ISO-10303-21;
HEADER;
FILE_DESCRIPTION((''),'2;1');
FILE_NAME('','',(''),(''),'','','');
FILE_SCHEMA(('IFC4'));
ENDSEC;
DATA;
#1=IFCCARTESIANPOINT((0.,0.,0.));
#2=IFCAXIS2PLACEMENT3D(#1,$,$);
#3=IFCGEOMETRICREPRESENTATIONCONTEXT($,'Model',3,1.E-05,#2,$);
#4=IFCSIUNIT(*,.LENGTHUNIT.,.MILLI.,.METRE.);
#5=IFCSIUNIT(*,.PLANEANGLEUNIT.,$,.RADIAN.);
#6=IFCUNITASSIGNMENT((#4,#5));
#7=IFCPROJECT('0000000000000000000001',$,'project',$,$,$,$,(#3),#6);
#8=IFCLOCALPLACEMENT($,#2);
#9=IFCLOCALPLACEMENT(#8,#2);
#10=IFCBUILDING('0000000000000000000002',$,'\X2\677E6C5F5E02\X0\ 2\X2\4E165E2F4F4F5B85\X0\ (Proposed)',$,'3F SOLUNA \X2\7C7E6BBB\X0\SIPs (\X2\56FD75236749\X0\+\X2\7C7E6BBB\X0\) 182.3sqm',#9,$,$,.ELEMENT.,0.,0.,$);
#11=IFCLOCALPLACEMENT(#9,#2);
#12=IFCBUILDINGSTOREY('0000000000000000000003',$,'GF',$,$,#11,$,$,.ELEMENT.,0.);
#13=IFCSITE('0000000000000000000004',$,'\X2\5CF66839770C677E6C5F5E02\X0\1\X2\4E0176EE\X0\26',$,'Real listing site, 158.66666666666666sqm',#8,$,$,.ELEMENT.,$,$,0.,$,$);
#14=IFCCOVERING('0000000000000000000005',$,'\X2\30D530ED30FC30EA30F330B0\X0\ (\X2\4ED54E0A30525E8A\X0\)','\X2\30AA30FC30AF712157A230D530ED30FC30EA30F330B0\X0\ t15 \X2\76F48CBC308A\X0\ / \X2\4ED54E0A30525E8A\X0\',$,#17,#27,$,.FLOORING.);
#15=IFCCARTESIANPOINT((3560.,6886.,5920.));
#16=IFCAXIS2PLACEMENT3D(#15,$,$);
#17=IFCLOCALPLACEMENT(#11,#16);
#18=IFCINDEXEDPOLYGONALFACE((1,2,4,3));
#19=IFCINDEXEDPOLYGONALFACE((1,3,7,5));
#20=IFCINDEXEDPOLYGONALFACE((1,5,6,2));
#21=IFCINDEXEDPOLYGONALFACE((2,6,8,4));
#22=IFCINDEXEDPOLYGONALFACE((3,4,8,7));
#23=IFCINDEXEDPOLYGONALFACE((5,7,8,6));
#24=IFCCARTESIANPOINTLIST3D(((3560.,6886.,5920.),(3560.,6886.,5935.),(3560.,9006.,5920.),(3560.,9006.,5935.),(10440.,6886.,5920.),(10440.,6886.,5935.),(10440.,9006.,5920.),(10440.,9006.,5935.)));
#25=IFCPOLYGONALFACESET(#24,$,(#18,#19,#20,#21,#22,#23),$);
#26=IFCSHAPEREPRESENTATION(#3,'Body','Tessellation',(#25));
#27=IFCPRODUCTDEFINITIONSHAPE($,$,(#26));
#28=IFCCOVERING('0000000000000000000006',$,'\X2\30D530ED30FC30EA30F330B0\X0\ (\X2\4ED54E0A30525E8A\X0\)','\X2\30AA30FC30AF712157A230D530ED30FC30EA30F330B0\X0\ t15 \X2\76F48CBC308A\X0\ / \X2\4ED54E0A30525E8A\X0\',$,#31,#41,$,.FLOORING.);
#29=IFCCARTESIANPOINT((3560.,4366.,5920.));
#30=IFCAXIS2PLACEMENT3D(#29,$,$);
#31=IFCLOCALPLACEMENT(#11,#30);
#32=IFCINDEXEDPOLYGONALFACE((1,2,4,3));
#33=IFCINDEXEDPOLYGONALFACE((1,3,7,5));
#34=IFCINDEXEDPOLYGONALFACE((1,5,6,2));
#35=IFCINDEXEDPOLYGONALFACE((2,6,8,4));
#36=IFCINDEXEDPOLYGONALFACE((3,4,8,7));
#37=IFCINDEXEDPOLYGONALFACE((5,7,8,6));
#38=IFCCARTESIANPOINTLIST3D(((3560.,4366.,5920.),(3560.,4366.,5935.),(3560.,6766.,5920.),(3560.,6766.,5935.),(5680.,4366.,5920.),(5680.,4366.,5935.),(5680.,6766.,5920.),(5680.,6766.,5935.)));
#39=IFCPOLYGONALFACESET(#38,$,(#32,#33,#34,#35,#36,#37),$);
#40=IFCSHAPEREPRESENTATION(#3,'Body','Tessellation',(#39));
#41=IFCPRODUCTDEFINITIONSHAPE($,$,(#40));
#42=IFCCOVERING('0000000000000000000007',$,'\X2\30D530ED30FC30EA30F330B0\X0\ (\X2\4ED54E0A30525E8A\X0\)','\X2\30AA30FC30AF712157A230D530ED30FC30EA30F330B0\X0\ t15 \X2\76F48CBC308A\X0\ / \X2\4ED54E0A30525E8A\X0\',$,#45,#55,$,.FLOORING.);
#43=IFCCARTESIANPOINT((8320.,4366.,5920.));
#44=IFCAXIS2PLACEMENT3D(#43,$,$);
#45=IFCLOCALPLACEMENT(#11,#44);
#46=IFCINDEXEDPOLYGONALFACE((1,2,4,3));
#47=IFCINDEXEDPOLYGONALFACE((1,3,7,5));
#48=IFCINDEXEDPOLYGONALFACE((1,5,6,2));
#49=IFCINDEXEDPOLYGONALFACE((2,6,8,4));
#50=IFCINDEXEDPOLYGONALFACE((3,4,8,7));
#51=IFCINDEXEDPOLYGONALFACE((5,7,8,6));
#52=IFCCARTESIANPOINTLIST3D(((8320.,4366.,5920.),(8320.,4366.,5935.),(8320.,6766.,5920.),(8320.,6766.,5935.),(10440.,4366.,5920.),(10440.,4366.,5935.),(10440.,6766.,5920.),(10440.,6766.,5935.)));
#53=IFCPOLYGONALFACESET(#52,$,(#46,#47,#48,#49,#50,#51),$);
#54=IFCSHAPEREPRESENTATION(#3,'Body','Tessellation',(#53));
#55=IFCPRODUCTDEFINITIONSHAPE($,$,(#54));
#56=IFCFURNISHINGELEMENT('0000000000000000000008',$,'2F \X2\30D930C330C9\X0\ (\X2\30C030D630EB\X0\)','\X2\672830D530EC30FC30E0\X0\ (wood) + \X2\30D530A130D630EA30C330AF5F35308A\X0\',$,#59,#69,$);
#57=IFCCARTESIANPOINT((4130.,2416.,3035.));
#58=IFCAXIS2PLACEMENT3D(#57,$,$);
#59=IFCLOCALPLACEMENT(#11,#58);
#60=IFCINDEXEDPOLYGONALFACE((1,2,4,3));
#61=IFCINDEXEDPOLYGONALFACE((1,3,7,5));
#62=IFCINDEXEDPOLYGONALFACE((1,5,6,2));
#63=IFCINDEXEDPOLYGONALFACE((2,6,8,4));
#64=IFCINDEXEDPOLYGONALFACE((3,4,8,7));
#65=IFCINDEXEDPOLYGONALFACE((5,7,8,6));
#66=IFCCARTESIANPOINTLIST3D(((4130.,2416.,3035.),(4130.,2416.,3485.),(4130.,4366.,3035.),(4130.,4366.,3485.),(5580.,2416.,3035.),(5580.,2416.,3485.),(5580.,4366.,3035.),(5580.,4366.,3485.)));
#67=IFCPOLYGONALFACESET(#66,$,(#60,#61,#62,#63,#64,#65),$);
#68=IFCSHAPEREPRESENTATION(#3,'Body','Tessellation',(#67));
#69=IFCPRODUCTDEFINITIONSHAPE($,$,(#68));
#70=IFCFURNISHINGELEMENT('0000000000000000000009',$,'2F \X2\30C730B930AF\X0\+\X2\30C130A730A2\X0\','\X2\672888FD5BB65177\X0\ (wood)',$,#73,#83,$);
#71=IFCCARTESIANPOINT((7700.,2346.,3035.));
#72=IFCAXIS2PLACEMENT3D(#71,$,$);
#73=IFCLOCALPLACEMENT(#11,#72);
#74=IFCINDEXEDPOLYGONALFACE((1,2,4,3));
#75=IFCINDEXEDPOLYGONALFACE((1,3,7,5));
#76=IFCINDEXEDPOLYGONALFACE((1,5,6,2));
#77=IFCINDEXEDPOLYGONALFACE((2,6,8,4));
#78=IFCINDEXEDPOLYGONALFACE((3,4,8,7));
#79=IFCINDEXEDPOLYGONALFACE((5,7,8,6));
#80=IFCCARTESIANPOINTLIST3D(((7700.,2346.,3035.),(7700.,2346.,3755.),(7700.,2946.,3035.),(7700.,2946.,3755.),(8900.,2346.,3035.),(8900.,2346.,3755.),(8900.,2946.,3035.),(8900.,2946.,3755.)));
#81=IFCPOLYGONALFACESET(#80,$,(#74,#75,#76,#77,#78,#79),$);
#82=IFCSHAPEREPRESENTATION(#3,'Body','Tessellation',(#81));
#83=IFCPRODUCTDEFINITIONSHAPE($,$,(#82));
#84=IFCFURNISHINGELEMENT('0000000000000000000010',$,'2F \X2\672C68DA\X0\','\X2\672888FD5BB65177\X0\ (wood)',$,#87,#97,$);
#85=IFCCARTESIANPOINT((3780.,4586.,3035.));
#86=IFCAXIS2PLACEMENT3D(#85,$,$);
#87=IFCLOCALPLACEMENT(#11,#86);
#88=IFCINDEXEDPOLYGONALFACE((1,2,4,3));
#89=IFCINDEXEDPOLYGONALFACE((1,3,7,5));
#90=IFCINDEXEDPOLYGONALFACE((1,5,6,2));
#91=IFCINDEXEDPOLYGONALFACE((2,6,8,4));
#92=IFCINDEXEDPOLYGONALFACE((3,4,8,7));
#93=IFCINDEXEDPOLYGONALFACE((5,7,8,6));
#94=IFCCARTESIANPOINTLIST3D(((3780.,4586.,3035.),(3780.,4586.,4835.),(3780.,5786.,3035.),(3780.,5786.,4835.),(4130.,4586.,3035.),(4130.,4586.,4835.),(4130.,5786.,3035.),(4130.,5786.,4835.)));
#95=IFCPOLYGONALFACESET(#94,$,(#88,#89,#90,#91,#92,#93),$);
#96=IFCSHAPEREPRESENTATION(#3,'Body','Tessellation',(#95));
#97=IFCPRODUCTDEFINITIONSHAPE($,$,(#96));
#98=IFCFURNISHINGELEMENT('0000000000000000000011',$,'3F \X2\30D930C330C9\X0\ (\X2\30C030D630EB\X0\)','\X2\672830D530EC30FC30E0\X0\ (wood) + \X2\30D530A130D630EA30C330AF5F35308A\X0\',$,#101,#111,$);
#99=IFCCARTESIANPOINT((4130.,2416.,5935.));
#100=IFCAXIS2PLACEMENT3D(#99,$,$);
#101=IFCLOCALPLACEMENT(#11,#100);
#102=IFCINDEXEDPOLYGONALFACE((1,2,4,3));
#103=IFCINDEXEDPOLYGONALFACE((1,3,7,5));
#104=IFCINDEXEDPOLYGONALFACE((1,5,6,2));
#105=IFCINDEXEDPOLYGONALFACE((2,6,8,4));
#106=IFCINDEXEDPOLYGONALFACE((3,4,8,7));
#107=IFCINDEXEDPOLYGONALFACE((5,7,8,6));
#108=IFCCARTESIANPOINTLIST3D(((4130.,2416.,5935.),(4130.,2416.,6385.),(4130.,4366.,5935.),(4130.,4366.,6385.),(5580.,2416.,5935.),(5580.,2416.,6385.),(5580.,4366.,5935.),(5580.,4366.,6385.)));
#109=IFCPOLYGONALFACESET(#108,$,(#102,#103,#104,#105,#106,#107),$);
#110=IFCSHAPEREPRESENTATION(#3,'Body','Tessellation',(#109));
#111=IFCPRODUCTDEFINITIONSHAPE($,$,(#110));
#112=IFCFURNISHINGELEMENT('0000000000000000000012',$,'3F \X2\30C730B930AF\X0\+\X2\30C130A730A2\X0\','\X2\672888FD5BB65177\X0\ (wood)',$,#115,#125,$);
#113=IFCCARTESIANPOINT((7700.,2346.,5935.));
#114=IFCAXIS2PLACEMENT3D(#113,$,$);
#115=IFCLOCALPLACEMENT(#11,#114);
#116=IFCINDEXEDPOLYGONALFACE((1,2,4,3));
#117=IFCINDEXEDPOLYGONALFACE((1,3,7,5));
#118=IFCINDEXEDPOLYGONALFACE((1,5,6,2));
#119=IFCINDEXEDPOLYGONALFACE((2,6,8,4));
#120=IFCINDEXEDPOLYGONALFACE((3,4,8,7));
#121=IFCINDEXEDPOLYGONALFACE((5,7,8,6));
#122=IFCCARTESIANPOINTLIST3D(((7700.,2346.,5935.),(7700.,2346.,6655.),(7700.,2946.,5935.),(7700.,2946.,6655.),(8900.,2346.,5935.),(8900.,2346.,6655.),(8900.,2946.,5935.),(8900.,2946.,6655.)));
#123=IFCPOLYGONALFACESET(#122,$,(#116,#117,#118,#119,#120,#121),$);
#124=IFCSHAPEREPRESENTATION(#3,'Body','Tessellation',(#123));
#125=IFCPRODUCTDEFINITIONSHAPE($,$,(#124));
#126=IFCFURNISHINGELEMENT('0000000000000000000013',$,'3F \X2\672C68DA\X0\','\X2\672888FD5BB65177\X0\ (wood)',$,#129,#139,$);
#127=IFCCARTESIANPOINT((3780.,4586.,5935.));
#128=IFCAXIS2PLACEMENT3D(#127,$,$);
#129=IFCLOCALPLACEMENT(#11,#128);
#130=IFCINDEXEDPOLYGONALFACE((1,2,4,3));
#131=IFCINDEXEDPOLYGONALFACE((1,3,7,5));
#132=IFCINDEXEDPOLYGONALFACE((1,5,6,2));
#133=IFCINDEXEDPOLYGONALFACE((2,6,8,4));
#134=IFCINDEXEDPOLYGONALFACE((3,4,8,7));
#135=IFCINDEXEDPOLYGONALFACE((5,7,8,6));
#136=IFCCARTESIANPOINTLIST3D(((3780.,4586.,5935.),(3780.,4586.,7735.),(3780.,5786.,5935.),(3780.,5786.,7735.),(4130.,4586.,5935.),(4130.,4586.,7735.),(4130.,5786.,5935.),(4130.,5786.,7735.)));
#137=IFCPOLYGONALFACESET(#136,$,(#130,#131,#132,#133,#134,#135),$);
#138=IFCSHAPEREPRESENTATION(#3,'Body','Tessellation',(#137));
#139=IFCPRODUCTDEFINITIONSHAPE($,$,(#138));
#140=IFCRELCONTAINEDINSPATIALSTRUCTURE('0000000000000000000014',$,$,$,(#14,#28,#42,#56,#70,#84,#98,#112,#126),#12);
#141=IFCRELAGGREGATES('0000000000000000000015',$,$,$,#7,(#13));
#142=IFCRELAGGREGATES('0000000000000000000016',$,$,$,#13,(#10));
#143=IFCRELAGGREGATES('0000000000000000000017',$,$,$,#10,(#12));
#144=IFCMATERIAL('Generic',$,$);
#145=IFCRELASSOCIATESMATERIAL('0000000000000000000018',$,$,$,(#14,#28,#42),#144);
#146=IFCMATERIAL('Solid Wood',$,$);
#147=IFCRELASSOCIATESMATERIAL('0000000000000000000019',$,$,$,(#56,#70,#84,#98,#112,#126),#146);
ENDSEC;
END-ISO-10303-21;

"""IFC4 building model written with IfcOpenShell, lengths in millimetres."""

from ifc_helpers import new_model, si_unit, frame, frame_2d, origin, place, context, project, spatial, rectangle, extrude, material, element, save


model = new_model("IFC4")

# Units and contexts
model_context = context("Model", 3, precision=1e-05, world=origin())
ifc_project = project(units=[si_unit("LENGTHUNIT", "METRE", prefix="MILLI"), si_unit("PLANEANGLEUNIT", "RADIAN")], contexts=[model_context])

# Site, building, storey
site_placement = place(None, origin())
site = spatial("IfcSite", under=ifc_project, at=site_placement, Name="島根県松江市1丁目26", ObjectType="Real listing site, 158.66666666666666sqm", CompositionType="ELEMENT", RefElevation=0.0)
building_placement = place(site_placement, origin())
building = spatial("IfcBuilding", under=site, at=building_placement, Name="松江市 2世帯住宅 (Proposed)", ObjectType="3F SOLUNA 籾殻SIPs (国産杉+籾殻) 182.3sqm", CompositionType="ELEMENT", ElevationOfRefHeight=0.0, ElevationOfTerrain=0.0)
storey_placement = place(building_placement, origin())
storey = spatial("IfcBuildingStorey", under=building, at=storey_placement, Name="GF", CompositionType="ELEMENT", Elevation=0.0)

# Shared definitions
ifc_material_1 = material(Name="Solid Wood")

# Shared definitions
ifc_material_2 = material(Name="Generic")

# Coverings
covering_1_placement = place(storey_placement, frame((3560.0, 6886.0, 5920.0)))
element("IfcCovering", 1, at=covering_1_placement, inside=storey, material=ifc_material_2, Name="フローリング (仕上げ床)", Description="オーク無垢フローリング t15 直貼り / 仕上げ床", PredefinedType="FLOORING", context=model_context, shape_type="SweptSolid", body=[
    extrude(rectangle(XDim=6880.0, YDim=2120.0, at=frame_2d((3440.0, 1060.0))), frame((3560.0, 6886.0, 5920.0)), (0.0, 0.0, 1.0), 15.0),
])
covering_2_placement = place(storey_placement, frame((3560.0, 4366.0, 5920.0)))
element("IfcCovering", 2, at=covering_2_placement, inside=storey, material=ifc_material_2, Name="フローリング (仕上げ床)", Description="オーク無垢フローリング t15 直貼り / 仕上げ床", PredefinedType="FLOORING", context=model_context, shape_type="SweptSolid", body=[
    extrude(rectangle(XDim=2120.0, YDim=2400.0, at=frame_2d((1060.0, 1200.0))), frame((3560.0, 4366.0, 5920.0)), (0.0, 0.0, 1.0), 15.0),
])
covering_3_placement = place(storey_placement, frame((8320.0, 4366.0, 5920.0)))
element("IfcCovering", 3, at=covering_3_placement, inside=storey, material=ifc_material_2, Name="フローリング (仕上げ床)", Description="オーク無垢フローリング t15 直貼り / 仕上げ床", PredefinedType="FLOORING", context=model_context, shape_type="SweptSolid", body=[
    extrude(rectangle(XDim=2120.0, YDim=2400.0, at=frame_2d((1060.0, 1200.0))), frame((8320.0, 4366.0, 5920.0)), (0.0, 0.0, 1.0), 15.0),
])

# Furnishing elements
furnishing_1_placement = place(storey_placement, frame((4130.0, 2416.0, 3035.0)))
element("IfcFurnishingElement", 4, at=furnishing_1_placement, inside=storey, material=ifc_material_1, Name="2F ベッド (ダブル)", Description="木フレーム (wood) + ファブリック張り", context=model_context, shape_type="SweptSolid", body=[
    extrude(rectangle(XDim=1450.0, YDim=1950.0, at=frame_2d((725.0, 975.0))), frame((4130.0, 2416.0, 3035.0)), (0.0, 0.0, 1.0), 450.0),
])
furnishing_2_placement = place(storey_placement, frame((7700.0, 2346.0, 3035.0)))
element("IfcFurnishingElement", 5, at=furnishing_2_placement, inside=storey, material=ifc_material_1, Name="2F デスク+チェア", Description="木製家具 (wood)", context=model_context, shape_type="SweptSolid", body=[
    extrude(rectangle(XDim=1200.0, YDim=600.0, at=frame_2d((600.0, 300.0))), frame((7700.0, 2346.0, 3035.0)), (0.0, 0.0, 1.0), 720.0),
])
furnishing_3_placement = place(storey_placement, frame((3780.0, 4586.0, 3035.0)))
element("IfcFurnishingElement", 6, at=furnishing_3_placement, inside=storey, material=ifc_material_1, Name="2F 本棚", Description="木製家具 (wood)", context=model_context, shape_type="SweptSolid", body=[
    extrude(rectangle(XDim=350.0, YDim=1200.0, at=frame_2d((175.0, 600.0))), frame((3780.0, 4586.0, 3035.0)), (0.0, 0.0, 1.0), 1800.0),
])
furnishing_4_placement = place(storey_placement, frame((4130.0, 2416.0, 5935.0)))
element("IfcFurnishingElement", 7, at=furnishing_4_placement, inside=storey, material=ifc_material_1, Name="3F ベッド (ダブル)", Description="木フレーム (wood) + ファブリック張り", context=model_context, shape_type="SweptSolid", body=[
    extrude(rectangle(XDim=1450.0, YDim=1950.0, at=frame_2d((725.0, 975.0))), frame((4130.0, 2416.0, 5935.0)), (0.0, 0.0, 1.0), 450.0),
])
furnishing_5_placement = place(storey_placement, frame((7700.0, 2346.0, 5935.0)))
element("IfcFurnishingElement", 8, at=furnishing_5_placement, inside=storey, material=ifc_material_1, Name="3F デスク+チェア", Description="木製家具 (wood)", context=model_context, shape_type="SweptSolid", body=[
    extrude(rectangle(XDim=1200.0, YDim=600.0, at=frame_2d((600.0, 300.0))), frame((7700.0, 2346.0, 5935.0)), (0.0, 0.0, 1.0), 720.0),
])
furnishing_6_placement = place(storey_placement, frame((3780.0, 4586.0, 5935.0)))
element("IfcFurnishingElement", 9, at=furnishing_6_placement, inside=storey, material=ifc_material_1, Name="3F 本棚", Description="木製家具 (wood)", context=model_context, shape_type="SweptSolid", body=[
    extrude(rectangle(XDim=350.0, YDim=1200.0, at=frame_2d((175.0, 600.0))), frame((3780.0, 4586.0, 5935.0)), (0.0, 0.0, 1.0), 1800.0),
])

save(model, "model.ifc")
